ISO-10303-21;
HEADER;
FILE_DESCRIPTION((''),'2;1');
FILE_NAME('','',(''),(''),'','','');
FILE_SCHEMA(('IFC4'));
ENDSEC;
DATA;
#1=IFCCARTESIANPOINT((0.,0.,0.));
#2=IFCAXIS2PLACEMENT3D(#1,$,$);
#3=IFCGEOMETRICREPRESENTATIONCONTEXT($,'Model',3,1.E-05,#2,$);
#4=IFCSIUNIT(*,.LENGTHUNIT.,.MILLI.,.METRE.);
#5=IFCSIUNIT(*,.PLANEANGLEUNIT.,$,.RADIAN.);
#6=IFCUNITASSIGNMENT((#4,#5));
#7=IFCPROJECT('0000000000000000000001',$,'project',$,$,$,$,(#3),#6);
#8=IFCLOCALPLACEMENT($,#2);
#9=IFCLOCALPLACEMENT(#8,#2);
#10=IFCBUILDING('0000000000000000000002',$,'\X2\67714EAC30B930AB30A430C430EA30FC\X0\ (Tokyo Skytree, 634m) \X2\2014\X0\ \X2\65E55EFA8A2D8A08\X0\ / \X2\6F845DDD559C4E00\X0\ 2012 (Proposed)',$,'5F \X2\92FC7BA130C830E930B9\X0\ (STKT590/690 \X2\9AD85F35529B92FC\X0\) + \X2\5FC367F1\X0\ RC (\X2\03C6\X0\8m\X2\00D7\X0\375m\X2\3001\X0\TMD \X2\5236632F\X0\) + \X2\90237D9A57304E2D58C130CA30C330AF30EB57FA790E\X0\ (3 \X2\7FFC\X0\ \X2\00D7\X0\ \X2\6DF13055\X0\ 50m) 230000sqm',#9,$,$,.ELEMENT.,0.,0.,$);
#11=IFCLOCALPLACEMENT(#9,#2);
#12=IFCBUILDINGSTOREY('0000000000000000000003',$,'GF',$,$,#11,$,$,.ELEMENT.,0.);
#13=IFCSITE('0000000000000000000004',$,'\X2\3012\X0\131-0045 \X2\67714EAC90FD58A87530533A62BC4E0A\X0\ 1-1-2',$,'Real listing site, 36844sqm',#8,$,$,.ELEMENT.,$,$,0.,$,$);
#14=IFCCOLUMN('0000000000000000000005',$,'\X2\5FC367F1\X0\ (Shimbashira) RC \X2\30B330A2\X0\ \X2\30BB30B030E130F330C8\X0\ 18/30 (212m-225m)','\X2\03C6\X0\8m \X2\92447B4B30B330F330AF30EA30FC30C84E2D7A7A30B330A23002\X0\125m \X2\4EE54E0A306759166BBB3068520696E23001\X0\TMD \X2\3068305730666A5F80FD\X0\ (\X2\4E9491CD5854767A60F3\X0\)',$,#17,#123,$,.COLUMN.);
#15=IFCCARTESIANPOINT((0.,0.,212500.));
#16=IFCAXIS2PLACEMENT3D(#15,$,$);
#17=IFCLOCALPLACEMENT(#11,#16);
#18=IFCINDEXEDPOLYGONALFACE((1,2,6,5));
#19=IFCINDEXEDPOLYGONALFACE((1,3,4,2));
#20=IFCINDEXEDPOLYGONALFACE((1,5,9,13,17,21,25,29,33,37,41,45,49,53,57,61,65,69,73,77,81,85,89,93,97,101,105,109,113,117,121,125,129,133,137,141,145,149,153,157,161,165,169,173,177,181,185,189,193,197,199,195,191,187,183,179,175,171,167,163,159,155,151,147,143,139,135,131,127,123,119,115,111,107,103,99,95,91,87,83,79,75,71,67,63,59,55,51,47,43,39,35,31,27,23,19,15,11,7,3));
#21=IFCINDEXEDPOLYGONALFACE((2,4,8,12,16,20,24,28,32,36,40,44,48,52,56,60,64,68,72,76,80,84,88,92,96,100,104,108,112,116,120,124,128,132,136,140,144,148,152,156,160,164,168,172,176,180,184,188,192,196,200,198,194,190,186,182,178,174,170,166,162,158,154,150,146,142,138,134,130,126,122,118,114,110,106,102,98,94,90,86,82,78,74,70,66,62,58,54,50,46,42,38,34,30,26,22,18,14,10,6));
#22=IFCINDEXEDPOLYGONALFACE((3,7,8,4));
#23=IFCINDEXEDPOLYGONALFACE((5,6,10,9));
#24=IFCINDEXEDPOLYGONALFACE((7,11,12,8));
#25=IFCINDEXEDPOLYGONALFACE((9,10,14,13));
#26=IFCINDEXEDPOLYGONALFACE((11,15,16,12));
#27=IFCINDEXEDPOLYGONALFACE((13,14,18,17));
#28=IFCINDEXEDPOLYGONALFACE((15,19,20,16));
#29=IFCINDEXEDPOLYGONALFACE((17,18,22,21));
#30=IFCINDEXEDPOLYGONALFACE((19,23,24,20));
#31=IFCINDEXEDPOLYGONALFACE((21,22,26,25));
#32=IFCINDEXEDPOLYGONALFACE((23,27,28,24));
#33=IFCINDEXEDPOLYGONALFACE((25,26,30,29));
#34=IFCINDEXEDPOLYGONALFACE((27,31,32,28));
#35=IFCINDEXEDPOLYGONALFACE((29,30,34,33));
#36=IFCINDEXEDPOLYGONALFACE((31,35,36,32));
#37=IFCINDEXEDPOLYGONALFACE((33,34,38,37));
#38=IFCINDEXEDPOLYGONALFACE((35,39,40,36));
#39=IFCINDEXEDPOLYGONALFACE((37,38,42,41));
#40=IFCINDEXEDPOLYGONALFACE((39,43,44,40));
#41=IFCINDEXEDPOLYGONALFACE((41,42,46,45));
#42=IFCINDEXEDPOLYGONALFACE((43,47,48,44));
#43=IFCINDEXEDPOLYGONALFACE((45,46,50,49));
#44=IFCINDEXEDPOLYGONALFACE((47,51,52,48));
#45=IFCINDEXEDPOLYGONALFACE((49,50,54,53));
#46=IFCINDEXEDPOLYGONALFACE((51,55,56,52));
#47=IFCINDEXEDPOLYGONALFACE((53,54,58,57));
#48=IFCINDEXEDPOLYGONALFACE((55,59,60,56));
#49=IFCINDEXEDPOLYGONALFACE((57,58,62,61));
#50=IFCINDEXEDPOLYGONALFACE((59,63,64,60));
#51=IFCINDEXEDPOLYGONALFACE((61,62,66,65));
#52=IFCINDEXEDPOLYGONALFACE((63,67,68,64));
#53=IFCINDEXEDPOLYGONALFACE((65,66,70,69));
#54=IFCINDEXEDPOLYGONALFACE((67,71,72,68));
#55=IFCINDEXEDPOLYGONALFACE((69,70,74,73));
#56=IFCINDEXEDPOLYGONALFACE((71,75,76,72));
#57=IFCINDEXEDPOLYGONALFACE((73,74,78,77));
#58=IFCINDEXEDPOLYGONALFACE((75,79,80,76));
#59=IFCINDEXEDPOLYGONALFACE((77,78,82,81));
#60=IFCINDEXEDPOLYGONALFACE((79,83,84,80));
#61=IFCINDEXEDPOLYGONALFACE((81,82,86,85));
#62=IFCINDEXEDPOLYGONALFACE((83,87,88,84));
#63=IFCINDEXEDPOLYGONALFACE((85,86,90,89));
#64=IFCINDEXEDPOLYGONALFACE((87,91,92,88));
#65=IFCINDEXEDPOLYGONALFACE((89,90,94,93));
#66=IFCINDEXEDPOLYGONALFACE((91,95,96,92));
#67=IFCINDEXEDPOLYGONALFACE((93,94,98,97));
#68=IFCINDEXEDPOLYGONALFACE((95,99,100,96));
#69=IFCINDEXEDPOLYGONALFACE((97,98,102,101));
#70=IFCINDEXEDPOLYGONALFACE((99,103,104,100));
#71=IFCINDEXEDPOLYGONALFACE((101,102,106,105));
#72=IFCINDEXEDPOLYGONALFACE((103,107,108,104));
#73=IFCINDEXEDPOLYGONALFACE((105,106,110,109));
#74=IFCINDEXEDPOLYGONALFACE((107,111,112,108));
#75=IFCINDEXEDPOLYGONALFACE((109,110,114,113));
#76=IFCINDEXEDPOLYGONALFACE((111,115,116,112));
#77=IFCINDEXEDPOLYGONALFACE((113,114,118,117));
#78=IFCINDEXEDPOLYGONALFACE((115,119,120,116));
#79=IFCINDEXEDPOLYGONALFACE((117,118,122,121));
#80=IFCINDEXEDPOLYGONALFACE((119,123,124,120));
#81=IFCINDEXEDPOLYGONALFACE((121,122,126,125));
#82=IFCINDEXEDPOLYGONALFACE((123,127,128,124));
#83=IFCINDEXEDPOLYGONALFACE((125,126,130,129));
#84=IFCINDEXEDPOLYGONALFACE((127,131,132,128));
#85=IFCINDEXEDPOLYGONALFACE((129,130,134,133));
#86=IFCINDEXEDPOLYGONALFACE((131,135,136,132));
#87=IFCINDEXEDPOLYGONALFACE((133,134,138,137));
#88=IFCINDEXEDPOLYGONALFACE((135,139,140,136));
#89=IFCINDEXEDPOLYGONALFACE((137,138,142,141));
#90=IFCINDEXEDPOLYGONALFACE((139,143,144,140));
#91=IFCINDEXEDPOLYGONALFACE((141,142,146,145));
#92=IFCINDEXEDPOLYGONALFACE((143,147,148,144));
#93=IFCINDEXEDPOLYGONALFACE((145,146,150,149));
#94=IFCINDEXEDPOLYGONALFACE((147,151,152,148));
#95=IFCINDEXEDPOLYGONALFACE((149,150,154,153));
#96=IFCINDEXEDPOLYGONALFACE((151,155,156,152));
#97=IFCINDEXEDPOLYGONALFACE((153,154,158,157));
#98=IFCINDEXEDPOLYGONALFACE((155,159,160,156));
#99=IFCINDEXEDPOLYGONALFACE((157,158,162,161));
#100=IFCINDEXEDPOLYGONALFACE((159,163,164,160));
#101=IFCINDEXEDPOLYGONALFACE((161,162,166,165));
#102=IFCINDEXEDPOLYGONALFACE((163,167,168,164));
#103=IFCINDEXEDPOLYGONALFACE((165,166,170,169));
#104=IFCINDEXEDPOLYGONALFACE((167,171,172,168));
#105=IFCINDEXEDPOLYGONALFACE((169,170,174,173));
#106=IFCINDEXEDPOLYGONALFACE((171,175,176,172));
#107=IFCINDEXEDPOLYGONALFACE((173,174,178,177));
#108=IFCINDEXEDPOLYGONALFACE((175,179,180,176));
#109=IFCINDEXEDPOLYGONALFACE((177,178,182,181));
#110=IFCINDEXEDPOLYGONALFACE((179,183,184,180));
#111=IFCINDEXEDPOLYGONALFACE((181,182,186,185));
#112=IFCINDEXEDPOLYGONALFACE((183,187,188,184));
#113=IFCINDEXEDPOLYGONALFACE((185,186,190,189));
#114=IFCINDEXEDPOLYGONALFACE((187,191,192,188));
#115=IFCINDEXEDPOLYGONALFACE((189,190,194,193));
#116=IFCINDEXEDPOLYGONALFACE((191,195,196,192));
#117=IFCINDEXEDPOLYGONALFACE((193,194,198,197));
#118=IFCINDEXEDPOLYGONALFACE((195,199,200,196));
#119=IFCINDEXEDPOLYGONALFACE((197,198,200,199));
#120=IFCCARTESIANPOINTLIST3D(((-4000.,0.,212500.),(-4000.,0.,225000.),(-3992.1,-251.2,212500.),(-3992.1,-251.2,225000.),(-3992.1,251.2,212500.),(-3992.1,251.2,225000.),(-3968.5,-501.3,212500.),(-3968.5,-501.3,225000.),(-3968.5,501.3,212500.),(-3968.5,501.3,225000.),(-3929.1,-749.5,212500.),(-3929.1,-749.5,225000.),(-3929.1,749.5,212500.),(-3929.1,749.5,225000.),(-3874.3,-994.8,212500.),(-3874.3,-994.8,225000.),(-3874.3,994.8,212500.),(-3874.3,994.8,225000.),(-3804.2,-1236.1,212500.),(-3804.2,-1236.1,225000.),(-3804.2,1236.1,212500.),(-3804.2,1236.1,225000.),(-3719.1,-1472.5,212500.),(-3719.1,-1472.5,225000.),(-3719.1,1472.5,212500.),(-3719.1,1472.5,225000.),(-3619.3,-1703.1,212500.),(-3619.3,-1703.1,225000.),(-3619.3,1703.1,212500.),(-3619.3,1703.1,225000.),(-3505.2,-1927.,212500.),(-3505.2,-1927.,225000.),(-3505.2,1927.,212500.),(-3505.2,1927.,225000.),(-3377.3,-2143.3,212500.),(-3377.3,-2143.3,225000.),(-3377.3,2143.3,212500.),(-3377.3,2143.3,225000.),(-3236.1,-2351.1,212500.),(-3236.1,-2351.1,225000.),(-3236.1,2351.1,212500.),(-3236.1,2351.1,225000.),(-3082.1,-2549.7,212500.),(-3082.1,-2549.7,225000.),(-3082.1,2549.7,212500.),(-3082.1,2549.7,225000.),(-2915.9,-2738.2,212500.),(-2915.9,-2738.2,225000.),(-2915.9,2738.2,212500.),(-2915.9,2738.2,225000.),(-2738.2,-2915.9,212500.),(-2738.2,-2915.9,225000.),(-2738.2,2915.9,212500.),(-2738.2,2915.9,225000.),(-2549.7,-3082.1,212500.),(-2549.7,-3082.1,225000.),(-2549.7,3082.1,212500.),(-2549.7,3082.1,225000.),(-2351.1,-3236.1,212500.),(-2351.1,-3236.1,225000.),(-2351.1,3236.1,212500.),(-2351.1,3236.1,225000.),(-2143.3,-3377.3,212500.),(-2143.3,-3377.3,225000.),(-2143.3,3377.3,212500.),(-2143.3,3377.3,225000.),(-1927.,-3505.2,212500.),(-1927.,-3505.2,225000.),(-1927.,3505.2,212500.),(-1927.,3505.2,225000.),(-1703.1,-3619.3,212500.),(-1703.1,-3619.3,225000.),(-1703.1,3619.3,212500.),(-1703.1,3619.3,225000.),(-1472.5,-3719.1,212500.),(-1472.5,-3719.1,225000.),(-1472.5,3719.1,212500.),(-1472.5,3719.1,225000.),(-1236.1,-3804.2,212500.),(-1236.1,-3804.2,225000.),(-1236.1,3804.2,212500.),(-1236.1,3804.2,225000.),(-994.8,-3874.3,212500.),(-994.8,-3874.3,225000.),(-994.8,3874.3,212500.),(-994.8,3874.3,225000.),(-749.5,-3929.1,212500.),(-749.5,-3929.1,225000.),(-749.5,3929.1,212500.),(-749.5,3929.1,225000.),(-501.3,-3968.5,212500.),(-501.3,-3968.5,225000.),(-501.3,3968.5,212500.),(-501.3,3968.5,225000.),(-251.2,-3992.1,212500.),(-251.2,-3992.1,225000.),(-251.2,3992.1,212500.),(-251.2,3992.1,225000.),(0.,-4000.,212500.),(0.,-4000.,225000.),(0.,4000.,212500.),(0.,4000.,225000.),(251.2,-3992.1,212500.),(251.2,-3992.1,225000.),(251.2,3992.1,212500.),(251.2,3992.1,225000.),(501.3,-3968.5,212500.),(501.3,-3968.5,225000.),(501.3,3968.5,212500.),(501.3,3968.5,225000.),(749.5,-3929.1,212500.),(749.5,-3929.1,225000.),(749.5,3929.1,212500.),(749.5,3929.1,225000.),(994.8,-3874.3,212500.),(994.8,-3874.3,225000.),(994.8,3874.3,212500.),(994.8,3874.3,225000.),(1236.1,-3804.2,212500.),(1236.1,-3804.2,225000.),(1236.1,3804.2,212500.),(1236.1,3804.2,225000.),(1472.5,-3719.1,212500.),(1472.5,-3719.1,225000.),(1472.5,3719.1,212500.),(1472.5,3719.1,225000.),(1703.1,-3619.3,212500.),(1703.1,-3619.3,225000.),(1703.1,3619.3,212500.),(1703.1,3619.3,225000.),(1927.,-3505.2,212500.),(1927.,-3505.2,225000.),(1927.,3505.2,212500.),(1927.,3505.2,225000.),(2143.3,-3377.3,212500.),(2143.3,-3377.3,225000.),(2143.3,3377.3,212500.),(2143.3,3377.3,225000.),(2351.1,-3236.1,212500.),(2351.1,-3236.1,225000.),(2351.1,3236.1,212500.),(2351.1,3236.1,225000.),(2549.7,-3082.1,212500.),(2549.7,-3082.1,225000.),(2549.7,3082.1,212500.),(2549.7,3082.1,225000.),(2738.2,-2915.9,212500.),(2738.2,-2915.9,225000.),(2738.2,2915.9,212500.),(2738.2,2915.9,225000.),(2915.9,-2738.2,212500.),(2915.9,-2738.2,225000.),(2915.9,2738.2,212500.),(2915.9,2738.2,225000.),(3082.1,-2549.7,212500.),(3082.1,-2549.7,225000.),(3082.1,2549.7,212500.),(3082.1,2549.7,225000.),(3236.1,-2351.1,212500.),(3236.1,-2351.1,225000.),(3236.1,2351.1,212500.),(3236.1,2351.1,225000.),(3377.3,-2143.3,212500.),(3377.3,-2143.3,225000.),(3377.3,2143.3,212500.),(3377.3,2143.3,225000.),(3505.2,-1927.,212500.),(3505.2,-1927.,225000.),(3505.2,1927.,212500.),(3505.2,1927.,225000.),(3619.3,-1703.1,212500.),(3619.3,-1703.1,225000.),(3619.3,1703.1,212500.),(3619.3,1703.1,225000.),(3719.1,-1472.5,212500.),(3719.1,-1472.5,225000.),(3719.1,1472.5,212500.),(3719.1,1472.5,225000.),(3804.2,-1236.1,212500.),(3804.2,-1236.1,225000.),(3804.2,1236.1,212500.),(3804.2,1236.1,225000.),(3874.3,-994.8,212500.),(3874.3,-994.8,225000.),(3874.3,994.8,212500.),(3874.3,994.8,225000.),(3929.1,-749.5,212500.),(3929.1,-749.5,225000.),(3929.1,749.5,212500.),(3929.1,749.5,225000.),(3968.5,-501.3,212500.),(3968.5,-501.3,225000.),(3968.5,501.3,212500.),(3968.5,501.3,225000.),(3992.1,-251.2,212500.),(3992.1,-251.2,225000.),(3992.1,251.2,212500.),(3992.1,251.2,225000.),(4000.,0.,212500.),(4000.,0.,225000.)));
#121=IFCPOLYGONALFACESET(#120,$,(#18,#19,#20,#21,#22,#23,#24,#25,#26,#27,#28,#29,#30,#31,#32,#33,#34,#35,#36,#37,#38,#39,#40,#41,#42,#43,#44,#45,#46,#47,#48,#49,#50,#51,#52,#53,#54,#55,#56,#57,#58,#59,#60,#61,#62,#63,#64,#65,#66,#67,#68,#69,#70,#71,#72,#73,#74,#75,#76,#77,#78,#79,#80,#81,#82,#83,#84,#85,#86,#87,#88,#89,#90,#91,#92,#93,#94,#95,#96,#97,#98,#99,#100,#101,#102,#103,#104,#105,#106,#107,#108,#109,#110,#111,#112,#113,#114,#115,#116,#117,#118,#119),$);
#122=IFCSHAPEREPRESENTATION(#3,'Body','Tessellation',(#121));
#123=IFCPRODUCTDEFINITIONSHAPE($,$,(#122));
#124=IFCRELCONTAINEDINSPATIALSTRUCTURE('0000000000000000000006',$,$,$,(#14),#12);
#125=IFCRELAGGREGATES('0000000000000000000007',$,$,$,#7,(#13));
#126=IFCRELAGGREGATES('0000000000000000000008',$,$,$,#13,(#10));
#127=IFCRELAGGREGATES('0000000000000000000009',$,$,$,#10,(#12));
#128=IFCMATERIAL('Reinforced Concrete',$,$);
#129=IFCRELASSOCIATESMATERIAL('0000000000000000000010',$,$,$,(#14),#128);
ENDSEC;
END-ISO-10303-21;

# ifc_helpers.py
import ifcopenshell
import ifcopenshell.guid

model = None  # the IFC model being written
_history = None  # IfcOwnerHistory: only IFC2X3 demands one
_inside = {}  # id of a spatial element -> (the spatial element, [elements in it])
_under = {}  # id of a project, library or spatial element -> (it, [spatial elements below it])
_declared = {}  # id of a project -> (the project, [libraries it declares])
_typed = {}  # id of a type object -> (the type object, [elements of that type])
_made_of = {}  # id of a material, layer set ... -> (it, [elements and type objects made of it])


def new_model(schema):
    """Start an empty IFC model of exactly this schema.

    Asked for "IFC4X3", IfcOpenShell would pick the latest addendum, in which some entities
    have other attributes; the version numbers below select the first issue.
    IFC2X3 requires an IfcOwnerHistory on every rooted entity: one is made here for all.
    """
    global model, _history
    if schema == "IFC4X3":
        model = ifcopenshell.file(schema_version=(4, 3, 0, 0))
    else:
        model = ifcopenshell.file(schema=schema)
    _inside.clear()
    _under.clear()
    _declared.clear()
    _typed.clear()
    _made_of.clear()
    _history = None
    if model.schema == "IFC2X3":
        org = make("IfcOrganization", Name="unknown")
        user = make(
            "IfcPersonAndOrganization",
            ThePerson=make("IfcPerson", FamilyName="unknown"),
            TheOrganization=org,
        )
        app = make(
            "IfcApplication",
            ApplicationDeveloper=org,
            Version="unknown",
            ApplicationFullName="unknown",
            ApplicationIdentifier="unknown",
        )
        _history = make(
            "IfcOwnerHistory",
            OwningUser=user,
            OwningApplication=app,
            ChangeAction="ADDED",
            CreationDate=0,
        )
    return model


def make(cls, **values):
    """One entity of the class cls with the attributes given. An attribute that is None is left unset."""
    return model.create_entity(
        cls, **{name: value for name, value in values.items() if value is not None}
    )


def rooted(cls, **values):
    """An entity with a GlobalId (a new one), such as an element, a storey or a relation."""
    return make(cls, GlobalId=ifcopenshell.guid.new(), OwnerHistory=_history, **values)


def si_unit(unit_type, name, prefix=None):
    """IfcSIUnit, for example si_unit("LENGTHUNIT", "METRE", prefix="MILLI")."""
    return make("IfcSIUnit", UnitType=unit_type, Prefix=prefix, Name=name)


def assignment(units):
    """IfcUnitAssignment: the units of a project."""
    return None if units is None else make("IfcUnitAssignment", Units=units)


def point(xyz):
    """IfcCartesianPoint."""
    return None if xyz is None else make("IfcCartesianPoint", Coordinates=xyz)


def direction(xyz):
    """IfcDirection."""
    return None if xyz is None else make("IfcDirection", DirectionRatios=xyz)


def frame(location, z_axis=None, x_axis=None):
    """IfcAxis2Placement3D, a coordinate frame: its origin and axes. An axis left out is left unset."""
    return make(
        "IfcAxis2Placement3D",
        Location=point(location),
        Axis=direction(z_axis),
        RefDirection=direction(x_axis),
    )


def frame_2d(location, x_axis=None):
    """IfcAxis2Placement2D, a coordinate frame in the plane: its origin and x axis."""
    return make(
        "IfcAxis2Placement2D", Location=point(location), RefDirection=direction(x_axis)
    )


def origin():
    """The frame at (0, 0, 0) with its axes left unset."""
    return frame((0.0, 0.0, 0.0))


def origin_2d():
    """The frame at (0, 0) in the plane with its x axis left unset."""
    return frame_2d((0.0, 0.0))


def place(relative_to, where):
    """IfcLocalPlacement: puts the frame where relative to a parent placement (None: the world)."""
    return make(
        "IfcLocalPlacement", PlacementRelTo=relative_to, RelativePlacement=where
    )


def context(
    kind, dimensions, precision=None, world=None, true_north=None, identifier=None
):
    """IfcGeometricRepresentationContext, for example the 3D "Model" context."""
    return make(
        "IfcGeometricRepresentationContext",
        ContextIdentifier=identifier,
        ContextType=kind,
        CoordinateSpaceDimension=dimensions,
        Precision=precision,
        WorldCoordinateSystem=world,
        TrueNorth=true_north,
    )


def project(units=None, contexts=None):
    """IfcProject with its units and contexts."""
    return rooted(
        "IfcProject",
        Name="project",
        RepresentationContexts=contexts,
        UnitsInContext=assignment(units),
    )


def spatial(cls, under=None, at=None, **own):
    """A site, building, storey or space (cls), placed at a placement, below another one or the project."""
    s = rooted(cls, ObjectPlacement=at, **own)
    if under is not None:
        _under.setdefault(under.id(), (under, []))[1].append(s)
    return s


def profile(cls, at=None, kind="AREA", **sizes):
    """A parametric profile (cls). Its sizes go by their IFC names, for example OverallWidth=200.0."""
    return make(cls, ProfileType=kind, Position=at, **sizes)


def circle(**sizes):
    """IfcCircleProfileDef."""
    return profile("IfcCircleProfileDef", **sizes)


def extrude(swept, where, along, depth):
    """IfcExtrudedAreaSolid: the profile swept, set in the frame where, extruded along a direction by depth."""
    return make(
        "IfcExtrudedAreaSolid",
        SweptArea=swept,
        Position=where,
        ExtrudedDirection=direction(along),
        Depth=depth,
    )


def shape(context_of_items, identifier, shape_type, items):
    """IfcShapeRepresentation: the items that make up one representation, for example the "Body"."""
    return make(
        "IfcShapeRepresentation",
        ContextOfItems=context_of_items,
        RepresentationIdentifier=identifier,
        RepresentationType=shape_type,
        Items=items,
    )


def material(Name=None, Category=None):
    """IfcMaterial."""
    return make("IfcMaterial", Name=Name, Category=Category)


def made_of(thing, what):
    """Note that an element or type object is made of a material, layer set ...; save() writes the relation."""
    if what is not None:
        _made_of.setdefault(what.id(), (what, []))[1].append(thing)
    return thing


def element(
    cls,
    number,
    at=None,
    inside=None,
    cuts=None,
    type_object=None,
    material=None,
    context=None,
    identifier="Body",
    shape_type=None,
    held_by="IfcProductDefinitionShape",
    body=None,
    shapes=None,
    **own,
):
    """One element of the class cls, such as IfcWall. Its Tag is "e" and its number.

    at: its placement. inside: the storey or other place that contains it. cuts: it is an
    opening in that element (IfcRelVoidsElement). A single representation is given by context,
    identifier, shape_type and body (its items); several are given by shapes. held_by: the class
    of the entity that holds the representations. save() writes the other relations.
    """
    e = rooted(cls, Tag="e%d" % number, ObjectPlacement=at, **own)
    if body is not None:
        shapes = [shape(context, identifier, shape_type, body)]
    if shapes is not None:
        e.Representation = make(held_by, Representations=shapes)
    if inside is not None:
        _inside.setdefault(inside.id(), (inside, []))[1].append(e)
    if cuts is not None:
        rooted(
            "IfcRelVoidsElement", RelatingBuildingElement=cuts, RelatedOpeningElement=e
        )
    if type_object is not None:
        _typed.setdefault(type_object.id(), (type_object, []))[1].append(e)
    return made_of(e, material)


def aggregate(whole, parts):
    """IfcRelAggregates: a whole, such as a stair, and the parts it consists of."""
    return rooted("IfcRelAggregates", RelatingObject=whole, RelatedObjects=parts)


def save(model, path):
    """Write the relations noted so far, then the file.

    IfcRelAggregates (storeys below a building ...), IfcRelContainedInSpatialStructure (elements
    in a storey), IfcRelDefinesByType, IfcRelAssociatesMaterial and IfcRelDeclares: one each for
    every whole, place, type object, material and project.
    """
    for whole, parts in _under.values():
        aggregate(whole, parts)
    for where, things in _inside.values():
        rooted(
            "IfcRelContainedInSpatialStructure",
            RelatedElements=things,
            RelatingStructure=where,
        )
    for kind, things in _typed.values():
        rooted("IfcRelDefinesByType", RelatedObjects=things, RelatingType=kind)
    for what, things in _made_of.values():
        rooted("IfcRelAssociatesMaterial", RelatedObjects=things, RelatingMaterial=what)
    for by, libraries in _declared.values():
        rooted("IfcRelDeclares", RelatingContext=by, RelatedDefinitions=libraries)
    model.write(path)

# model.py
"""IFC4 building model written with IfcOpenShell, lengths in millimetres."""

from ifc_helpers import new_model, si_unit, frame, origin, origin_2d, place, context, project, spatial, circle, extrude, material, element, save


model = new_model("IFC4")

# Units and contexts
model_context = context("Model", 3, precision=1e-05, world=origin())
ifc_project = project(units=[si_unit("LENGTHUNIT", "METRE", prefix="MILLI"), si_unit("PLANEANGLEUNIT", "RADIAN")], contexts=[model_context])

# Site, building, storey
site_placement = place(None, origin())
site = spatial("IfcSite", under=ifc_project, at=site_placement, Name="〒131-0045 東京都墨田区押上 1-1-2", ObjectType="Real listing site, 36844sqm", CompositionType="ELEMENT", RefElevation=0.0)
building_placement = place(site_placement, origin())
building = spatial("IfcBuilding", under=site, at=building_placement, Name="東京スカイツリー (Tokyo Skytree, 634m) — 日建設計 / 澄川喜一 2012 (Proposed)", ObjectType="5F 鋼管トラス (STKT590/690 高張力鋼) + 心柱 RC (φ8m×375m、TMD 制振) + 連続地中壁ナックル基礎 (3 翼 × 深さ 50m) 230000sqm", CompositionType="ELEMENT", ElevationOfRefHeight=0.0, ElevationOfTerrain=0.0)
storey_placement = place(building_placement, origin())
storey = spatial("IfcBuildingStorey", under=building, at=storey_placement, Name="GF", CompositionType="ELEMENT", Elevation=0.0)

# Column
ifc_material_1 = material(Name="Reinforced Concrete")
column_1_placement = place(storey_placement, frame((0.0, 0.0, 212500.0)))
element("IfcColumn", 1, at=column_1_placement, inside=storey, material=ifc_material_1, Name="心柱 (Shimbashira) RC コア セグメント 18/30 (212m-225m)", Description="φ8m 鉄筋コンクリート中空コア。125m 以上で外殻と分離、TMD として機能 (五重塔発想)", PredefinedType="COLUMN", context=model_context, shape_type="SweptSolid", body=[
    extrude(circle(Radius=4000.0, at=origin_2d()), frame((0.0, 0.0, 212500.0)), (0.0, 0.0, 1.0), 12500.0),
])

save(model, "model.ifc")
